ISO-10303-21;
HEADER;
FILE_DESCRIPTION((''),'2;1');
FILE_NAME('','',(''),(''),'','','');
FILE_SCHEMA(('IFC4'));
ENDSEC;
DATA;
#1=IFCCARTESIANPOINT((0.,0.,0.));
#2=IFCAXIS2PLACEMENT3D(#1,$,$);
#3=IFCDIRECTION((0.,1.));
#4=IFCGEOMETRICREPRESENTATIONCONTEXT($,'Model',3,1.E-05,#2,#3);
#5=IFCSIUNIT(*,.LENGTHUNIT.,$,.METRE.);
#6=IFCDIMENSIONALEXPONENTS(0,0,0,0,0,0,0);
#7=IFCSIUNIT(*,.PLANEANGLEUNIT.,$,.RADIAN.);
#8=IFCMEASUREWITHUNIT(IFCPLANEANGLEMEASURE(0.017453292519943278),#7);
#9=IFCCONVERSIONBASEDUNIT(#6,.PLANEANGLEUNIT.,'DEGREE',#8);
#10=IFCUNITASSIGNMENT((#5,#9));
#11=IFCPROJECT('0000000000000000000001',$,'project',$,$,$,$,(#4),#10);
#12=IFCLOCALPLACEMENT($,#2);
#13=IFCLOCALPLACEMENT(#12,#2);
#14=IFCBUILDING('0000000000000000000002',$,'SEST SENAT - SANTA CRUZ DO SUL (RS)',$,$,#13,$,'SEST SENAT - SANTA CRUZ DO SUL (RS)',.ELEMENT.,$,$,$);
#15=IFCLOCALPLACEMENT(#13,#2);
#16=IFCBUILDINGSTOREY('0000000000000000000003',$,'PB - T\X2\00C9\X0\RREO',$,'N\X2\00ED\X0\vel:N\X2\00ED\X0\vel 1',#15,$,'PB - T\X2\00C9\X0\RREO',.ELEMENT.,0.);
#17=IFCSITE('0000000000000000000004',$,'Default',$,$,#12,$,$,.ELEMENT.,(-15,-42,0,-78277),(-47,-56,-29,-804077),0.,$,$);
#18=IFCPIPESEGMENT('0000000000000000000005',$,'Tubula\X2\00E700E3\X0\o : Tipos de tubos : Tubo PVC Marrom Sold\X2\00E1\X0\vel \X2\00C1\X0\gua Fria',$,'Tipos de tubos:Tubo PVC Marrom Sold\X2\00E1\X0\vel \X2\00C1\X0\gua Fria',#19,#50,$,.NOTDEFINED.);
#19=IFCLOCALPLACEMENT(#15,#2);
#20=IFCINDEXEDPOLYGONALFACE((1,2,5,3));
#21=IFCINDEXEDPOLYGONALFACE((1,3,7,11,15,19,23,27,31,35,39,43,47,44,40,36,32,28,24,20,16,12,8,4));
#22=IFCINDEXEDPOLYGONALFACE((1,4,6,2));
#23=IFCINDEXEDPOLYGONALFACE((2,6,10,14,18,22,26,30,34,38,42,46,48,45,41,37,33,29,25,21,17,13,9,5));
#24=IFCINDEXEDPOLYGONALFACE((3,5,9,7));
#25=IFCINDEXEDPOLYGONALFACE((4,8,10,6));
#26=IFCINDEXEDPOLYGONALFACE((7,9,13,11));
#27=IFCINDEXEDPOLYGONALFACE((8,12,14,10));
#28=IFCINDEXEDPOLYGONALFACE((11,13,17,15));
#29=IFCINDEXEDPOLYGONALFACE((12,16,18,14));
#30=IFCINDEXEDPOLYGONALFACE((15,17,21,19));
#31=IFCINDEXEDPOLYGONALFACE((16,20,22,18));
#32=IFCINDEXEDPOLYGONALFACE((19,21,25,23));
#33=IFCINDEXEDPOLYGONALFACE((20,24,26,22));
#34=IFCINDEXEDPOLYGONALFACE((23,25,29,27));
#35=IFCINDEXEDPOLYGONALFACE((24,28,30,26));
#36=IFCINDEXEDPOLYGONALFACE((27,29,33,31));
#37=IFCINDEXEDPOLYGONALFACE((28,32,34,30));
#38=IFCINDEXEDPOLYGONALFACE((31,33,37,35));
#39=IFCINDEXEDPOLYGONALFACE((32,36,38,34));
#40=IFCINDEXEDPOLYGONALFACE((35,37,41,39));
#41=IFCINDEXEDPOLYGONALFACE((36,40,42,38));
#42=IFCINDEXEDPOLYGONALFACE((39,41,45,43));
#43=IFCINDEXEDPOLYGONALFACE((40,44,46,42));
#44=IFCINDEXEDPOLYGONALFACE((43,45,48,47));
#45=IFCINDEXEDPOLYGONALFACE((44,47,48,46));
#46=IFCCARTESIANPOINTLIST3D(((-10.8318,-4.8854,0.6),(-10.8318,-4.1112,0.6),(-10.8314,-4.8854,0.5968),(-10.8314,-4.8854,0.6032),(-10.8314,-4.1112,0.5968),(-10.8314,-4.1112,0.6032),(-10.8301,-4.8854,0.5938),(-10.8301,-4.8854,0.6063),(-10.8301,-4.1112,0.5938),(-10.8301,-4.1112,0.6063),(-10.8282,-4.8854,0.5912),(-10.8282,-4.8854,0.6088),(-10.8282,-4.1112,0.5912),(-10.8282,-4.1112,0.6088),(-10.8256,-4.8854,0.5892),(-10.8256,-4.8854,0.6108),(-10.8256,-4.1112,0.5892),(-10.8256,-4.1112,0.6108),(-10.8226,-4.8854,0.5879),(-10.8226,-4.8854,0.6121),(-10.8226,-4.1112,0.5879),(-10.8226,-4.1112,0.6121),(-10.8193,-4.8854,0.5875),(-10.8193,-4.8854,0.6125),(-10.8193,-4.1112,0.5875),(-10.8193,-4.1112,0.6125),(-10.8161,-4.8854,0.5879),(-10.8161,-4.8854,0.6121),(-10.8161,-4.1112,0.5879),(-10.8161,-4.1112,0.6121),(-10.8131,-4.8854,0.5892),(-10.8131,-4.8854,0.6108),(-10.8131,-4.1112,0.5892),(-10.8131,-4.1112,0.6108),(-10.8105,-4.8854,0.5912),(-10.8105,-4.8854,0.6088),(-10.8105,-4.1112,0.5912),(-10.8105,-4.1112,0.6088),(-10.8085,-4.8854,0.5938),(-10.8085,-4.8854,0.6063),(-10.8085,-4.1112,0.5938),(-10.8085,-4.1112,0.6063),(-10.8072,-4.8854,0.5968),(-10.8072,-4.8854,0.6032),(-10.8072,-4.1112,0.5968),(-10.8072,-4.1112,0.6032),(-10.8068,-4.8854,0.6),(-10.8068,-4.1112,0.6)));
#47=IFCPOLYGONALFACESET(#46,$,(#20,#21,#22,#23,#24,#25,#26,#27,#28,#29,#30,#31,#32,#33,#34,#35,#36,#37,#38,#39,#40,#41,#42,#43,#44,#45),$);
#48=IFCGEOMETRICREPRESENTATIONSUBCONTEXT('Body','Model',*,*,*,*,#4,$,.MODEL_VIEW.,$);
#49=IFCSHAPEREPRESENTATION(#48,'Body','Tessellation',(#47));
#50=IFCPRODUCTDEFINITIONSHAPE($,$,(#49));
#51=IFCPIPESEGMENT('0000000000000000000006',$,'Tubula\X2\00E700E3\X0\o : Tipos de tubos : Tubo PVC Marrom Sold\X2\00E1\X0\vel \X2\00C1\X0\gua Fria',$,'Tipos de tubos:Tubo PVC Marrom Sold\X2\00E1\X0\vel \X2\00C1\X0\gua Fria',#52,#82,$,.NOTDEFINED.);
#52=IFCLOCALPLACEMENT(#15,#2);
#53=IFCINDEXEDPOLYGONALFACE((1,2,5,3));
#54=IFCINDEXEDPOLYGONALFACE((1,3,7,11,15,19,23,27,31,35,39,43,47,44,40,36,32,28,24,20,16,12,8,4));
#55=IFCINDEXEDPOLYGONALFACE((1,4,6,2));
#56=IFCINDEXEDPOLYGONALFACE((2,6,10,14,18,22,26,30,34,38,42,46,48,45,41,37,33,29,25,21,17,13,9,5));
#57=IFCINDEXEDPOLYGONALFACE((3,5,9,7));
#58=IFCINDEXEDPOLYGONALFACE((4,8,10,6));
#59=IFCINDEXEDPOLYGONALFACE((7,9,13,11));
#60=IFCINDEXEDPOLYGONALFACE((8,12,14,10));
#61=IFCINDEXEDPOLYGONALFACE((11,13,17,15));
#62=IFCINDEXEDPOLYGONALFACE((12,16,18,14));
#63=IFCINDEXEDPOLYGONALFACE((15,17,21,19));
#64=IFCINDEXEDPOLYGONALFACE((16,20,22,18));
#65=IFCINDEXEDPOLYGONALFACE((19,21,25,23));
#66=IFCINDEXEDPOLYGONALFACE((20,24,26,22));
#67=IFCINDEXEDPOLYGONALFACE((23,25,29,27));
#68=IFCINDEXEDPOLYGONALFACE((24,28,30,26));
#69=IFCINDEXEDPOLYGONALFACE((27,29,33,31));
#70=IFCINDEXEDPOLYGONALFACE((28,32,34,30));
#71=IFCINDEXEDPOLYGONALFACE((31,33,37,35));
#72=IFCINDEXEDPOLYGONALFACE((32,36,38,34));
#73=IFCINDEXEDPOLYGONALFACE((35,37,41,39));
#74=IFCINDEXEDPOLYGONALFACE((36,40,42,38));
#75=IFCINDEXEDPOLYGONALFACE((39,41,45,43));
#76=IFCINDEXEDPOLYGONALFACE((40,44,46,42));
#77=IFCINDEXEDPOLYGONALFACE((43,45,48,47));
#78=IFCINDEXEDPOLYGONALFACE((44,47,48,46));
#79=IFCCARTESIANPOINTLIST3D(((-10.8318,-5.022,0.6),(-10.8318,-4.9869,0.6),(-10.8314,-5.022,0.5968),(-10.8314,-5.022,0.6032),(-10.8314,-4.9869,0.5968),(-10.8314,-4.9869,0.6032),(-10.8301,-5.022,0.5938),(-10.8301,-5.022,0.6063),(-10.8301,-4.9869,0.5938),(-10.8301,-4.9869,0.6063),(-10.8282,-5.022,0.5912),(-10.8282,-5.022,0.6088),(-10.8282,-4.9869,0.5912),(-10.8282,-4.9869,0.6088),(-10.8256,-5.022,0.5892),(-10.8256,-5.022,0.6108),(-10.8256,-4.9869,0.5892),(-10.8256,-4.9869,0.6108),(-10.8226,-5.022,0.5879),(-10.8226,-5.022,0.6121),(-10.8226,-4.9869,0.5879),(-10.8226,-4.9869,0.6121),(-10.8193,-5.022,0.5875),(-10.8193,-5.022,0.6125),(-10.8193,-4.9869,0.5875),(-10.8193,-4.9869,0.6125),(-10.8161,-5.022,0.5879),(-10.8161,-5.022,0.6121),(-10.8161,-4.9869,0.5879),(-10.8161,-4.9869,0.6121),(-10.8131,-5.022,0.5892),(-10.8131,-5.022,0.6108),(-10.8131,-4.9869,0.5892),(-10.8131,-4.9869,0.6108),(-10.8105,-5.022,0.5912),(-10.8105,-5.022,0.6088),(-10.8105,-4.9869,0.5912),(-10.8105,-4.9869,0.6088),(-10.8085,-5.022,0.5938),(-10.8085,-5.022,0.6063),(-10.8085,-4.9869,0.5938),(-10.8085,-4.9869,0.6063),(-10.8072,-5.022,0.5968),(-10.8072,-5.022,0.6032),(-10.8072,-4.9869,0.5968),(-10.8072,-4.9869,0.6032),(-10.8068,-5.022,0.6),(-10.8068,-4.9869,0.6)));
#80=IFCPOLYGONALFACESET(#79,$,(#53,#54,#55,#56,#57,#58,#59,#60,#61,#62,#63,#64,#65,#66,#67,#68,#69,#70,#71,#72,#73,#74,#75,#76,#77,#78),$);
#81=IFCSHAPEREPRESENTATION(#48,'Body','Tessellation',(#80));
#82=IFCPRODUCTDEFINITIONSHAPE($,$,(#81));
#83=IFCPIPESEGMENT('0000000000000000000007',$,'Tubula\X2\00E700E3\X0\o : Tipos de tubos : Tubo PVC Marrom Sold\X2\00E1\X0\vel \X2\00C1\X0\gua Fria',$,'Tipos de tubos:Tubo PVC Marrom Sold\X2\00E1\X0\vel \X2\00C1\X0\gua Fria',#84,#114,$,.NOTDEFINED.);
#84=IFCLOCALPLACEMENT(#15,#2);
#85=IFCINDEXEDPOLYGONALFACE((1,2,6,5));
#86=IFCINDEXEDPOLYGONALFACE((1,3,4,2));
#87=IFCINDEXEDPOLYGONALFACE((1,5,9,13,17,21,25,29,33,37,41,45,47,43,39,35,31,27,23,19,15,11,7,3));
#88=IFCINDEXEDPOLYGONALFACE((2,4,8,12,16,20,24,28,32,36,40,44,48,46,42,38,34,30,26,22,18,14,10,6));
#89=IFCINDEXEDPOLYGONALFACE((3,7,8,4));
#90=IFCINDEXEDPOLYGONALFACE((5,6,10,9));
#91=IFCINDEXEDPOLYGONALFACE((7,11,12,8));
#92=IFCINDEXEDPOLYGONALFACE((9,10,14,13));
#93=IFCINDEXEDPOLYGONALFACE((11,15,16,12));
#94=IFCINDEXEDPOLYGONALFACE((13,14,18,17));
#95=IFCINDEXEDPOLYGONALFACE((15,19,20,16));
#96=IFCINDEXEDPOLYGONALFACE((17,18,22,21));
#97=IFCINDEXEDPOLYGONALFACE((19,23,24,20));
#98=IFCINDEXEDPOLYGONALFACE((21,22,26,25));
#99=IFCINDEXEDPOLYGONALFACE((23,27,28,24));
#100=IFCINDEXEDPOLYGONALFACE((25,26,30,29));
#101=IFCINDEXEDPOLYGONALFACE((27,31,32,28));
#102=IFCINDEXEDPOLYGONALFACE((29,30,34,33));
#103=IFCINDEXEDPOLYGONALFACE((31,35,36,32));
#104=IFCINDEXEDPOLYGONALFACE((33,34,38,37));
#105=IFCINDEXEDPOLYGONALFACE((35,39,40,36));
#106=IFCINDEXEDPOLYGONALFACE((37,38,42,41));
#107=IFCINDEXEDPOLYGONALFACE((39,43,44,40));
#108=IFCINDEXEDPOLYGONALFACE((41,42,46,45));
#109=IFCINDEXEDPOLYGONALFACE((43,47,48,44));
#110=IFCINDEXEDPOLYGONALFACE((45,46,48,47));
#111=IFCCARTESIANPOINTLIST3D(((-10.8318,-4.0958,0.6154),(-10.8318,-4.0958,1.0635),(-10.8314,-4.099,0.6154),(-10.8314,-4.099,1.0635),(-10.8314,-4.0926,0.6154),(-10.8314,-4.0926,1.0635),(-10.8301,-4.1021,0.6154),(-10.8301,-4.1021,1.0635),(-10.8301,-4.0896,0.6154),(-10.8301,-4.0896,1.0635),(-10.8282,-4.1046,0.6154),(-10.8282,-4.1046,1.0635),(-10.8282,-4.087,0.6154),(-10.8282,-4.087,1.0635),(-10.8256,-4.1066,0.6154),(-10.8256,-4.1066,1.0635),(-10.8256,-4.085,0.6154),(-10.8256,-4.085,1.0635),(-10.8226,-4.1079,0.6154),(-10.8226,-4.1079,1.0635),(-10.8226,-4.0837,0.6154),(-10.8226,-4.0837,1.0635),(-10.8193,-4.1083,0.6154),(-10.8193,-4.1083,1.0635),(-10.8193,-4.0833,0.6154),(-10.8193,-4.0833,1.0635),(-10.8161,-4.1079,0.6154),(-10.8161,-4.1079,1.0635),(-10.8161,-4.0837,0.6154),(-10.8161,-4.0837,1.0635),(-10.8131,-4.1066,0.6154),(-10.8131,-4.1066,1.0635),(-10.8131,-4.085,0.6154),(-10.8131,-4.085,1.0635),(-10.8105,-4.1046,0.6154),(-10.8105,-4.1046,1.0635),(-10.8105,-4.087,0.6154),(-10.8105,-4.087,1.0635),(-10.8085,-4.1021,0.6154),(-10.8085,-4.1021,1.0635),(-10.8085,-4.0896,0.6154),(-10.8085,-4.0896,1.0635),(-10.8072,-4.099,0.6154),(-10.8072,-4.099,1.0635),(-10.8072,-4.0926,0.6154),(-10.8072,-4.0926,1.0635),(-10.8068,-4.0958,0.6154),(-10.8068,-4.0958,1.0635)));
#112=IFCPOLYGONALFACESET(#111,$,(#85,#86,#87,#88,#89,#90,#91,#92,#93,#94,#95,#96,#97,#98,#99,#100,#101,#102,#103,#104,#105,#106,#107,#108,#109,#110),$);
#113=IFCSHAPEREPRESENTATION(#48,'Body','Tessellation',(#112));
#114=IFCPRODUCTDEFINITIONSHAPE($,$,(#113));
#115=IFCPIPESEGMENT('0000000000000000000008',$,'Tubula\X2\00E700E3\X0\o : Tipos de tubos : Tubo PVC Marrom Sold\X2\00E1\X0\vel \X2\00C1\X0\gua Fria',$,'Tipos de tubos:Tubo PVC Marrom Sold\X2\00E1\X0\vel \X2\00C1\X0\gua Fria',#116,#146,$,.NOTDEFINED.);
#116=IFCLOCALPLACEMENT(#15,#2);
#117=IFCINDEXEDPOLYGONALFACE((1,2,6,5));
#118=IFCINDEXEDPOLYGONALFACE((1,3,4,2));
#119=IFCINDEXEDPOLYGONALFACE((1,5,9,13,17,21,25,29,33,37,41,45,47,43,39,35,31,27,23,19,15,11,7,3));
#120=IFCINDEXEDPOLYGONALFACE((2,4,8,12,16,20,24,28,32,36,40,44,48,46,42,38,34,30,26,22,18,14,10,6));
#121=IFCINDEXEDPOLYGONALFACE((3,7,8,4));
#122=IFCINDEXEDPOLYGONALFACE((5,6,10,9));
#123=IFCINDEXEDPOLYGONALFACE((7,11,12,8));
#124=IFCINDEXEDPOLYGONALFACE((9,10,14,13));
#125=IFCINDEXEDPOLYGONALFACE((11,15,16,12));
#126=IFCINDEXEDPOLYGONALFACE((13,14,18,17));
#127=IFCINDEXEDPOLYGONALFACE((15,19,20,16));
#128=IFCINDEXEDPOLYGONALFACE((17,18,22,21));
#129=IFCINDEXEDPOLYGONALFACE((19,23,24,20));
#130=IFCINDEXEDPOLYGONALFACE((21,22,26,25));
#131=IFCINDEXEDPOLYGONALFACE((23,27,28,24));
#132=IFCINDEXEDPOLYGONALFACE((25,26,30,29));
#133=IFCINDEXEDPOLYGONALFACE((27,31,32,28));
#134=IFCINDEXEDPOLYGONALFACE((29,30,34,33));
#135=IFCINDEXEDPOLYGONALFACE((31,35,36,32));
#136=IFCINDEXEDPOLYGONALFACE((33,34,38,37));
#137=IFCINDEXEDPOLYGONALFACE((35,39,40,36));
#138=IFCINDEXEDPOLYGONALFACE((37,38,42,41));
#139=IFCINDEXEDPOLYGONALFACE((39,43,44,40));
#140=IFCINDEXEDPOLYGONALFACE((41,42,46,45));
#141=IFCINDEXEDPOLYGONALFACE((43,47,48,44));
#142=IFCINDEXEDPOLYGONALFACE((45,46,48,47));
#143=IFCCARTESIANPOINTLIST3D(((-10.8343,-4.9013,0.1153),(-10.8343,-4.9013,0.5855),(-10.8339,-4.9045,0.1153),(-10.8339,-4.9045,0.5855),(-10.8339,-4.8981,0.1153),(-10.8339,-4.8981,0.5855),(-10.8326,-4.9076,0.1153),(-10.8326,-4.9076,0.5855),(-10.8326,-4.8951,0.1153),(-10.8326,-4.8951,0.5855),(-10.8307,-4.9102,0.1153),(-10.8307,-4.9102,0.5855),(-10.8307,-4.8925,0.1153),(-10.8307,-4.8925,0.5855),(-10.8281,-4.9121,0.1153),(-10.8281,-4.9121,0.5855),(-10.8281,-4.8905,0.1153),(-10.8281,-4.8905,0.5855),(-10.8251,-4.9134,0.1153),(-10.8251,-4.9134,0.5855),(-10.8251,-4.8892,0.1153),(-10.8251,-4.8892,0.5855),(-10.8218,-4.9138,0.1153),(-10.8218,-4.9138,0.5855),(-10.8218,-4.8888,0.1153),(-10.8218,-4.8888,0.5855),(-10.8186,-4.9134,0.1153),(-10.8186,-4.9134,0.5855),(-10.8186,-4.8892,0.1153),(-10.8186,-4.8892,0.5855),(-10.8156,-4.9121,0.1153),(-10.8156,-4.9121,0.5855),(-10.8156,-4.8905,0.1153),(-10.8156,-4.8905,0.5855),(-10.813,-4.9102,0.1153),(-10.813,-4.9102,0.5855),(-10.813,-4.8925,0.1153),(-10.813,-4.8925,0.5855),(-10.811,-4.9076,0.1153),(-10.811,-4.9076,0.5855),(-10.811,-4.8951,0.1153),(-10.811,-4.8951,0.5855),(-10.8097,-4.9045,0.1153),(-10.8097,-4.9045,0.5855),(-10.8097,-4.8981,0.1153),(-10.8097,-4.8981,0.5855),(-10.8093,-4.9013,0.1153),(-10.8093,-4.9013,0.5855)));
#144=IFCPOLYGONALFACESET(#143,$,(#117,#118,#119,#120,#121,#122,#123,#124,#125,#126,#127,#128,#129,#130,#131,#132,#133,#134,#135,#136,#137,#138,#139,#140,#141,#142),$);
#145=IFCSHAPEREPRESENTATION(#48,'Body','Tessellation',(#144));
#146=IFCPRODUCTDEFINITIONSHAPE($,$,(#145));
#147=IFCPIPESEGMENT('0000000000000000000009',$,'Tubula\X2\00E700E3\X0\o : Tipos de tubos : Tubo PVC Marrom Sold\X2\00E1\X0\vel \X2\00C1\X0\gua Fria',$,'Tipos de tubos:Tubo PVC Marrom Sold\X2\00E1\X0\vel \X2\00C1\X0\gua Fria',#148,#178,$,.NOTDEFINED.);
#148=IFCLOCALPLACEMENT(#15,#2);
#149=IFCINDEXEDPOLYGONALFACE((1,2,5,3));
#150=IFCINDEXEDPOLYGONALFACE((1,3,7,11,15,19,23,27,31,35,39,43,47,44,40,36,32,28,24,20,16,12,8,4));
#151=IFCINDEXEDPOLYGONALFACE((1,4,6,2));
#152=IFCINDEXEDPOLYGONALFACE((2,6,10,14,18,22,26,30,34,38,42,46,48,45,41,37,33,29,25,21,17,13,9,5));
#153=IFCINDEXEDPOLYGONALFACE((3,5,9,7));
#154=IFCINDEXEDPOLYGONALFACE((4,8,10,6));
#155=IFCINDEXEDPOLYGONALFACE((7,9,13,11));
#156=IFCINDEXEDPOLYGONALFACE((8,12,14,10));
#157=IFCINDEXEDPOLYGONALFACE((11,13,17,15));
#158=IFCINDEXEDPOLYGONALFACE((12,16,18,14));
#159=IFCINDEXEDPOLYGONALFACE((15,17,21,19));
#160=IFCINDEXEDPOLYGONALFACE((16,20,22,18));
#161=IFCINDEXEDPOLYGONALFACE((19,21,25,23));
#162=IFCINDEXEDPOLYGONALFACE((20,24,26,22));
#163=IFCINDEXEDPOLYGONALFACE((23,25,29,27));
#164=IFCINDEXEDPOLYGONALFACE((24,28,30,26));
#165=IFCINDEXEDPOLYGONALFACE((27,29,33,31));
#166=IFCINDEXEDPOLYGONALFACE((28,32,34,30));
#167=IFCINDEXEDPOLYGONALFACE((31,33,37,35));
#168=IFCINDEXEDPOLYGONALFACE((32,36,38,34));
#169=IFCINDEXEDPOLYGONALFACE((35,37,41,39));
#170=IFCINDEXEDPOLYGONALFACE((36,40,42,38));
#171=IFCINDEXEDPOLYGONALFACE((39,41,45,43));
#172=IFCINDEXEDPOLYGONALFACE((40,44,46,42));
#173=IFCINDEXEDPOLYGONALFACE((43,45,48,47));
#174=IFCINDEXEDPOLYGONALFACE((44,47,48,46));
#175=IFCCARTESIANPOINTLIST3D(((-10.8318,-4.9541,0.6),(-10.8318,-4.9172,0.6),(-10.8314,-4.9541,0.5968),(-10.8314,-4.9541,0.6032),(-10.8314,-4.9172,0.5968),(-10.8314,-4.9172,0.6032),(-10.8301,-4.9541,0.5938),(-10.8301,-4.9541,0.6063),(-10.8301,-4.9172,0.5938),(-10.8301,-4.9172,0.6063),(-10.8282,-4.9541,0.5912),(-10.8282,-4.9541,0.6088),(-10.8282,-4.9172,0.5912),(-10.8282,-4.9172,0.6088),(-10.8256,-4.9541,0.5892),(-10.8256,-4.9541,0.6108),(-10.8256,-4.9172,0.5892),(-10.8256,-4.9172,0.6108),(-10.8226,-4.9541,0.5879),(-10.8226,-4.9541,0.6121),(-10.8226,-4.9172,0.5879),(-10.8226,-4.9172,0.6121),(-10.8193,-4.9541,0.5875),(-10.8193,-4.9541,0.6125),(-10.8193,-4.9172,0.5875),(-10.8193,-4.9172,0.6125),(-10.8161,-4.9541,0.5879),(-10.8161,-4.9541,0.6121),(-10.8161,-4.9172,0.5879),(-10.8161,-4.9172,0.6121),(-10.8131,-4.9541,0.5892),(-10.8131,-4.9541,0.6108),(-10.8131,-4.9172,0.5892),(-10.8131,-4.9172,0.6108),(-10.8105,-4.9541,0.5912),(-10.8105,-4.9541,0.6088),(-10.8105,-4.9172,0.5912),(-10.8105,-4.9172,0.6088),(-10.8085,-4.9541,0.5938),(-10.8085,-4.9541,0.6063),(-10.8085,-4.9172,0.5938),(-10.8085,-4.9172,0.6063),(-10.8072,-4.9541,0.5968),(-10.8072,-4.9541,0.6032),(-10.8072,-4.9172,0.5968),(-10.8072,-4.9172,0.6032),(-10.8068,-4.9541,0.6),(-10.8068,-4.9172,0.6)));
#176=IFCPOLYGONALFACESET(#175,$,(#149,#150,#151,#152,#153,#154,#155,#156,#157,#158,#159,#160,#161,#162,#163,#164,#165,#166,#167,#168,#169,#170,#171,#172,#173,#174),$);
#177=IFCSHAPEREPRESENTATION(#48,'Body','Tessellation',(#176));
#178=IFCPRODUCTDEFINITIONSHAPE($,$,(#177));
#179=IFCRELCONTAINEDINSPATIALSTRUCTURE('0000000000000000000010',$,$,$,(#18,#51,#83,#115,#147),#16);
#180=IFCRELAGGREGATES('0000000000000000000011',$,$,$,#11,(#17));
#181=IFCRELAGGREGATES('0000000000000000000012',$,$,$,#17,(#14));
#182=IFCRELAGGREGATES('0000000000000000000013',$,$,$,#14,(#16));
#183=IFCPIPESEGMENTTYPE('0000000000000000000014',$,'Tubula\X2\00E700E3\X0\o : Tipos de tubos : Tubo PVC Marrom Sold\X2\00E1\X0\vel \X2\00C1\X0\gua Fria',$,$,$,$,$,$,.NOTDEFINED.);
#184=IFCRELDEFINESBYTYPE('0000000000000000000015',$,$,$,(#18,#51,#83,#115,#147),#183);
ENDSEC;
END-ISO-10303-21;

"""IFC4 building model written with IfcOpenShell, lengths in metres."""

from ifc_helpers import new_model, entity, si_unit, converted_unit, direction, frame, origin, place, context, subcontext, project, spatial, arc, indexed_curve, outline, extrude, type_object, element, save


model = new_model("IFC4")

# Units and contexts
model_context = context("Model", 3, precision=1e-05, world=origin(), true_north=direction((0.0, 1.0)))
body_context = subcontext(model_context, "Body", "Model", "MODEL_VIEW")
ifc_project = project(units=[si_unit("LENGTHUNIT", "METRE"), converted_unit("PLANEANGLEUNIT", "DEGREE", entity("IfcPlaneAngleMeasure", 0.017453292519943278), si_unit("PLANEANGLEUNIT", "RADIAN"), dimensions=[0, 0, 0, 0, 0, 0, 0])], contexts=[model_context])

# Site, building, storey
site_placement = place(None, origin())
site = spatial("IfcSite", under=ifc_project, at=site_placement, Name="Default", CompositionType="ELEMENT", RefLatitude=(-15, -42, 0, -78277), RefLongitude=(-47, -56, -29, -804077), RefElevation=0.0)
building_placement = place(site_placement, origin())
building = spatial("IfcBuilding", under=site, at=building_placement, Name="SEST SENAT - SANTA CRUZ DO SUL (RS)", LongName="SEST SENAT - SANTA CRUZ DO SUL (RS)", CompositionType="ELEMENT")
storey_placement = place(building_placement, origin())
storey = spatial("IfcBuildingStorey", under=building, at=storey_placement, Name="PB - TÉRREO", ObjectType="Nível:Nível 1", LongName="PB - TÉRREO", CompositionType="ELEMENT", Elevation=0.0)

# Pipe segments
pipe_segment_type_1 = type_object("IfcPipeSegmentType", Name="Tubulação : Tipos de tubos : Tubo PVC Marrom Soldável Água Fria", PredefinedType="NOTDEFINED")
pipe_segment_1_placement = place(storey_placement, frame((-10.8334, -4.8854, 0.5859)))
element("IfcPipeSegment", 1, at=pipe_segment_1_placement, inside=storey, type_object=pipe_segment_type_1, Name="Tubulação : Tipos de tubos : Tubo PVC Marrom Soldável Água Fria", ObjectType="Tipos de tubos:Tubo PVC Marrom Soldável Água Fria", PredefinedType="NOTDEFINED", context=body_context, shape_type="SweptSolid", body=[
    extrude(outline(indexed_curve([(0.0125, 0.0), (0.0088, 0.0088), (0.0, 0.0125), (-0.0088, 0.0088), (-0.0125, 0.0), (-0.0088, -0.0088), (0.0, -0.0125), (0.0088, -0.0088)], segments=[arc(1, 2, 3), arc(3, 4, 5), arc(5, 6, 7), arc(7, 8, 1)], self_intersect=False)), frame((0.0141, 0.0, 0.0141), z_axis=(0.0, 1.0, 0.0), x_axis=(1.0, 0.0, 0.0)), (0.0, 0.0, 1.0), 0.7742),
])
pipe_segment_2_placement = place(storey_placement, frame((-10.8334, -5.022, 0.5859)))
element("IfcPipeSegment", 2, at=pipe_segment_2_placement, inside=storey, type_object=pipe_segment_type_1, Name="Tubulação : Tipos de tubos : Tubo PVC Marrom Soldável Água Fria", ObjectType="Tipos de tubos:Tubo PVC Marrom Soldável Água Fria", PredefinedType="NOTDEFINED", context=body_context, shape_type="SweptSolid", body=[
    extrude(outline(indexed_curve([(0.0125, 0.0), (0.0088, 0.0088), (0.0, 0.0125), (-0.0088, 0.0088), (-0.0125, 0.0), (-0.0088, -0.0088), (0.0, -0.0125), (0.0088, -0.0088)], segments=[arc(1, 2, 3), arc(3, 4, 5), arc(5, 6, 7), arc(7, 8, 1)], self_intersect=False)), frame((0.0141, 0.0, 0.0141), z_axis=(0.0, 1.0, 0.0), x_axis=(1.0, 0.0, 0.0)), (0.0, 0.0, 1.0), 0.035),
])
pipe_segment_3_placement = place(storey_placement, frame((-10.8334, -4.1099, 0.6154)))
element("IfcPipeSegment", 3, at=pipe_segment_3_placement, inside=storey, type_object=pipe_segment_type_1, Name="Tubulação : Tipos de tubos : Tubo PVC Marrom Soldável Água Fria", ObjectType="Tipos de tubos:Tubo PVC Marrom Soldável Água Fria", PredefinedType="NOTDEFINED", context=body_context, shape_type="SweptSolid", body=[
    extrude(outline(indexed_curve([(0.0125, 0.0), (0.0088, 0.0088), (0.0, 0.0125), (-0.0088, 0.0088), (-0.0125, 0.0), (-0.0088, -0.0088), (0.0, -0.0125), (0.0088, -0.0088)], segments=[arc(1, 2, 3), arc(3, 4, 5), arc(5, 6, 7), arc(7, 8, 1)], self_intersect=False)), frame((0.0141, 0.0141, 0.0), z_axis=(0.0, 0.0, 1.0), x_axis=(-1.0, 0.0, 0.0)), (0.0, 0.0, 1.0), 0.4481),
])
pipe_segment_4_placement = place(storey_placement, frame((-10.8359, -4.9154, 0.1153)))
element("IfcPipeSegment", 4, at=pipe_segment_4_placement, inside=storey, type_object=pipe_segment_type_1, Name="Tubulação : Tipos de tubos : Tubo PVC Marrom Soldável Água Fria", ObjectType="Tipos de tubos:Tubo PVC Marrom Soldável Água Fria", PredefinedType="NOTDEFINED", context=body_context, shape_type="SweptSolid", body=[
    extrude(outline(indexed_curve([(0.0125, 0.0), (0.0088, 0.0088), (0.0, 0.0125), (-0.0088, 0.0088), (-0.0125, 0.0), (-0.0088, -0.0088), (0.0, -0.0125), (0.0088, -0.0088)], segments=[arc(1, 2, 3), arc(3, 4, 5), arc(5, 6, 7), arc(7, 8, 1)], self_intersect=False)), frame((0.0141, 0.0141, 0.0)), (0.0, 0.0, 1.0), 0.4702),
])
pipe_segment_5_placement = place(storey_placement, frame((-10.8334, -4.9541, 0.5859)))
element("IfcPipeSegment", 5, at=pipe_segment_5_placement, inside=storey, type_object=pipe_segment_type_1, Name="Tubulação : Tipos de tubos : Tubo PVC Marrom Soldável Água Fria", ObjectType="Tipos de tubos:Tubo PVC Marrom Soldável Água Fria", PredefinedType="NOTDEFINED", context=body_context, shape_type="SweptSolid", body=[
    extrude(outline(indexed_curve([(0.0125, 0.0), (0.0088, 0.0088), (0.0, 0.0125), (-0.0088, 0.0088), (-0.0125, 0.0), (-0.0088, -0.0088), (0.0, -0.0125), (0.0088, -0.0088)], segments=[arc(1, 2, 3), arc(3, 4, 5), arc(5, 6, 7), arc(7, 8, 1)], self_intersect=False)), frame((0.0141, 0.0, 0.0141), z_axis=(0.0, 1.0, 0.0), x_axis=(1.0, 0.0, 0.0)), (0.0, 0.0, 1.0), 0.0369),
])

save(model, "model.ifc")
